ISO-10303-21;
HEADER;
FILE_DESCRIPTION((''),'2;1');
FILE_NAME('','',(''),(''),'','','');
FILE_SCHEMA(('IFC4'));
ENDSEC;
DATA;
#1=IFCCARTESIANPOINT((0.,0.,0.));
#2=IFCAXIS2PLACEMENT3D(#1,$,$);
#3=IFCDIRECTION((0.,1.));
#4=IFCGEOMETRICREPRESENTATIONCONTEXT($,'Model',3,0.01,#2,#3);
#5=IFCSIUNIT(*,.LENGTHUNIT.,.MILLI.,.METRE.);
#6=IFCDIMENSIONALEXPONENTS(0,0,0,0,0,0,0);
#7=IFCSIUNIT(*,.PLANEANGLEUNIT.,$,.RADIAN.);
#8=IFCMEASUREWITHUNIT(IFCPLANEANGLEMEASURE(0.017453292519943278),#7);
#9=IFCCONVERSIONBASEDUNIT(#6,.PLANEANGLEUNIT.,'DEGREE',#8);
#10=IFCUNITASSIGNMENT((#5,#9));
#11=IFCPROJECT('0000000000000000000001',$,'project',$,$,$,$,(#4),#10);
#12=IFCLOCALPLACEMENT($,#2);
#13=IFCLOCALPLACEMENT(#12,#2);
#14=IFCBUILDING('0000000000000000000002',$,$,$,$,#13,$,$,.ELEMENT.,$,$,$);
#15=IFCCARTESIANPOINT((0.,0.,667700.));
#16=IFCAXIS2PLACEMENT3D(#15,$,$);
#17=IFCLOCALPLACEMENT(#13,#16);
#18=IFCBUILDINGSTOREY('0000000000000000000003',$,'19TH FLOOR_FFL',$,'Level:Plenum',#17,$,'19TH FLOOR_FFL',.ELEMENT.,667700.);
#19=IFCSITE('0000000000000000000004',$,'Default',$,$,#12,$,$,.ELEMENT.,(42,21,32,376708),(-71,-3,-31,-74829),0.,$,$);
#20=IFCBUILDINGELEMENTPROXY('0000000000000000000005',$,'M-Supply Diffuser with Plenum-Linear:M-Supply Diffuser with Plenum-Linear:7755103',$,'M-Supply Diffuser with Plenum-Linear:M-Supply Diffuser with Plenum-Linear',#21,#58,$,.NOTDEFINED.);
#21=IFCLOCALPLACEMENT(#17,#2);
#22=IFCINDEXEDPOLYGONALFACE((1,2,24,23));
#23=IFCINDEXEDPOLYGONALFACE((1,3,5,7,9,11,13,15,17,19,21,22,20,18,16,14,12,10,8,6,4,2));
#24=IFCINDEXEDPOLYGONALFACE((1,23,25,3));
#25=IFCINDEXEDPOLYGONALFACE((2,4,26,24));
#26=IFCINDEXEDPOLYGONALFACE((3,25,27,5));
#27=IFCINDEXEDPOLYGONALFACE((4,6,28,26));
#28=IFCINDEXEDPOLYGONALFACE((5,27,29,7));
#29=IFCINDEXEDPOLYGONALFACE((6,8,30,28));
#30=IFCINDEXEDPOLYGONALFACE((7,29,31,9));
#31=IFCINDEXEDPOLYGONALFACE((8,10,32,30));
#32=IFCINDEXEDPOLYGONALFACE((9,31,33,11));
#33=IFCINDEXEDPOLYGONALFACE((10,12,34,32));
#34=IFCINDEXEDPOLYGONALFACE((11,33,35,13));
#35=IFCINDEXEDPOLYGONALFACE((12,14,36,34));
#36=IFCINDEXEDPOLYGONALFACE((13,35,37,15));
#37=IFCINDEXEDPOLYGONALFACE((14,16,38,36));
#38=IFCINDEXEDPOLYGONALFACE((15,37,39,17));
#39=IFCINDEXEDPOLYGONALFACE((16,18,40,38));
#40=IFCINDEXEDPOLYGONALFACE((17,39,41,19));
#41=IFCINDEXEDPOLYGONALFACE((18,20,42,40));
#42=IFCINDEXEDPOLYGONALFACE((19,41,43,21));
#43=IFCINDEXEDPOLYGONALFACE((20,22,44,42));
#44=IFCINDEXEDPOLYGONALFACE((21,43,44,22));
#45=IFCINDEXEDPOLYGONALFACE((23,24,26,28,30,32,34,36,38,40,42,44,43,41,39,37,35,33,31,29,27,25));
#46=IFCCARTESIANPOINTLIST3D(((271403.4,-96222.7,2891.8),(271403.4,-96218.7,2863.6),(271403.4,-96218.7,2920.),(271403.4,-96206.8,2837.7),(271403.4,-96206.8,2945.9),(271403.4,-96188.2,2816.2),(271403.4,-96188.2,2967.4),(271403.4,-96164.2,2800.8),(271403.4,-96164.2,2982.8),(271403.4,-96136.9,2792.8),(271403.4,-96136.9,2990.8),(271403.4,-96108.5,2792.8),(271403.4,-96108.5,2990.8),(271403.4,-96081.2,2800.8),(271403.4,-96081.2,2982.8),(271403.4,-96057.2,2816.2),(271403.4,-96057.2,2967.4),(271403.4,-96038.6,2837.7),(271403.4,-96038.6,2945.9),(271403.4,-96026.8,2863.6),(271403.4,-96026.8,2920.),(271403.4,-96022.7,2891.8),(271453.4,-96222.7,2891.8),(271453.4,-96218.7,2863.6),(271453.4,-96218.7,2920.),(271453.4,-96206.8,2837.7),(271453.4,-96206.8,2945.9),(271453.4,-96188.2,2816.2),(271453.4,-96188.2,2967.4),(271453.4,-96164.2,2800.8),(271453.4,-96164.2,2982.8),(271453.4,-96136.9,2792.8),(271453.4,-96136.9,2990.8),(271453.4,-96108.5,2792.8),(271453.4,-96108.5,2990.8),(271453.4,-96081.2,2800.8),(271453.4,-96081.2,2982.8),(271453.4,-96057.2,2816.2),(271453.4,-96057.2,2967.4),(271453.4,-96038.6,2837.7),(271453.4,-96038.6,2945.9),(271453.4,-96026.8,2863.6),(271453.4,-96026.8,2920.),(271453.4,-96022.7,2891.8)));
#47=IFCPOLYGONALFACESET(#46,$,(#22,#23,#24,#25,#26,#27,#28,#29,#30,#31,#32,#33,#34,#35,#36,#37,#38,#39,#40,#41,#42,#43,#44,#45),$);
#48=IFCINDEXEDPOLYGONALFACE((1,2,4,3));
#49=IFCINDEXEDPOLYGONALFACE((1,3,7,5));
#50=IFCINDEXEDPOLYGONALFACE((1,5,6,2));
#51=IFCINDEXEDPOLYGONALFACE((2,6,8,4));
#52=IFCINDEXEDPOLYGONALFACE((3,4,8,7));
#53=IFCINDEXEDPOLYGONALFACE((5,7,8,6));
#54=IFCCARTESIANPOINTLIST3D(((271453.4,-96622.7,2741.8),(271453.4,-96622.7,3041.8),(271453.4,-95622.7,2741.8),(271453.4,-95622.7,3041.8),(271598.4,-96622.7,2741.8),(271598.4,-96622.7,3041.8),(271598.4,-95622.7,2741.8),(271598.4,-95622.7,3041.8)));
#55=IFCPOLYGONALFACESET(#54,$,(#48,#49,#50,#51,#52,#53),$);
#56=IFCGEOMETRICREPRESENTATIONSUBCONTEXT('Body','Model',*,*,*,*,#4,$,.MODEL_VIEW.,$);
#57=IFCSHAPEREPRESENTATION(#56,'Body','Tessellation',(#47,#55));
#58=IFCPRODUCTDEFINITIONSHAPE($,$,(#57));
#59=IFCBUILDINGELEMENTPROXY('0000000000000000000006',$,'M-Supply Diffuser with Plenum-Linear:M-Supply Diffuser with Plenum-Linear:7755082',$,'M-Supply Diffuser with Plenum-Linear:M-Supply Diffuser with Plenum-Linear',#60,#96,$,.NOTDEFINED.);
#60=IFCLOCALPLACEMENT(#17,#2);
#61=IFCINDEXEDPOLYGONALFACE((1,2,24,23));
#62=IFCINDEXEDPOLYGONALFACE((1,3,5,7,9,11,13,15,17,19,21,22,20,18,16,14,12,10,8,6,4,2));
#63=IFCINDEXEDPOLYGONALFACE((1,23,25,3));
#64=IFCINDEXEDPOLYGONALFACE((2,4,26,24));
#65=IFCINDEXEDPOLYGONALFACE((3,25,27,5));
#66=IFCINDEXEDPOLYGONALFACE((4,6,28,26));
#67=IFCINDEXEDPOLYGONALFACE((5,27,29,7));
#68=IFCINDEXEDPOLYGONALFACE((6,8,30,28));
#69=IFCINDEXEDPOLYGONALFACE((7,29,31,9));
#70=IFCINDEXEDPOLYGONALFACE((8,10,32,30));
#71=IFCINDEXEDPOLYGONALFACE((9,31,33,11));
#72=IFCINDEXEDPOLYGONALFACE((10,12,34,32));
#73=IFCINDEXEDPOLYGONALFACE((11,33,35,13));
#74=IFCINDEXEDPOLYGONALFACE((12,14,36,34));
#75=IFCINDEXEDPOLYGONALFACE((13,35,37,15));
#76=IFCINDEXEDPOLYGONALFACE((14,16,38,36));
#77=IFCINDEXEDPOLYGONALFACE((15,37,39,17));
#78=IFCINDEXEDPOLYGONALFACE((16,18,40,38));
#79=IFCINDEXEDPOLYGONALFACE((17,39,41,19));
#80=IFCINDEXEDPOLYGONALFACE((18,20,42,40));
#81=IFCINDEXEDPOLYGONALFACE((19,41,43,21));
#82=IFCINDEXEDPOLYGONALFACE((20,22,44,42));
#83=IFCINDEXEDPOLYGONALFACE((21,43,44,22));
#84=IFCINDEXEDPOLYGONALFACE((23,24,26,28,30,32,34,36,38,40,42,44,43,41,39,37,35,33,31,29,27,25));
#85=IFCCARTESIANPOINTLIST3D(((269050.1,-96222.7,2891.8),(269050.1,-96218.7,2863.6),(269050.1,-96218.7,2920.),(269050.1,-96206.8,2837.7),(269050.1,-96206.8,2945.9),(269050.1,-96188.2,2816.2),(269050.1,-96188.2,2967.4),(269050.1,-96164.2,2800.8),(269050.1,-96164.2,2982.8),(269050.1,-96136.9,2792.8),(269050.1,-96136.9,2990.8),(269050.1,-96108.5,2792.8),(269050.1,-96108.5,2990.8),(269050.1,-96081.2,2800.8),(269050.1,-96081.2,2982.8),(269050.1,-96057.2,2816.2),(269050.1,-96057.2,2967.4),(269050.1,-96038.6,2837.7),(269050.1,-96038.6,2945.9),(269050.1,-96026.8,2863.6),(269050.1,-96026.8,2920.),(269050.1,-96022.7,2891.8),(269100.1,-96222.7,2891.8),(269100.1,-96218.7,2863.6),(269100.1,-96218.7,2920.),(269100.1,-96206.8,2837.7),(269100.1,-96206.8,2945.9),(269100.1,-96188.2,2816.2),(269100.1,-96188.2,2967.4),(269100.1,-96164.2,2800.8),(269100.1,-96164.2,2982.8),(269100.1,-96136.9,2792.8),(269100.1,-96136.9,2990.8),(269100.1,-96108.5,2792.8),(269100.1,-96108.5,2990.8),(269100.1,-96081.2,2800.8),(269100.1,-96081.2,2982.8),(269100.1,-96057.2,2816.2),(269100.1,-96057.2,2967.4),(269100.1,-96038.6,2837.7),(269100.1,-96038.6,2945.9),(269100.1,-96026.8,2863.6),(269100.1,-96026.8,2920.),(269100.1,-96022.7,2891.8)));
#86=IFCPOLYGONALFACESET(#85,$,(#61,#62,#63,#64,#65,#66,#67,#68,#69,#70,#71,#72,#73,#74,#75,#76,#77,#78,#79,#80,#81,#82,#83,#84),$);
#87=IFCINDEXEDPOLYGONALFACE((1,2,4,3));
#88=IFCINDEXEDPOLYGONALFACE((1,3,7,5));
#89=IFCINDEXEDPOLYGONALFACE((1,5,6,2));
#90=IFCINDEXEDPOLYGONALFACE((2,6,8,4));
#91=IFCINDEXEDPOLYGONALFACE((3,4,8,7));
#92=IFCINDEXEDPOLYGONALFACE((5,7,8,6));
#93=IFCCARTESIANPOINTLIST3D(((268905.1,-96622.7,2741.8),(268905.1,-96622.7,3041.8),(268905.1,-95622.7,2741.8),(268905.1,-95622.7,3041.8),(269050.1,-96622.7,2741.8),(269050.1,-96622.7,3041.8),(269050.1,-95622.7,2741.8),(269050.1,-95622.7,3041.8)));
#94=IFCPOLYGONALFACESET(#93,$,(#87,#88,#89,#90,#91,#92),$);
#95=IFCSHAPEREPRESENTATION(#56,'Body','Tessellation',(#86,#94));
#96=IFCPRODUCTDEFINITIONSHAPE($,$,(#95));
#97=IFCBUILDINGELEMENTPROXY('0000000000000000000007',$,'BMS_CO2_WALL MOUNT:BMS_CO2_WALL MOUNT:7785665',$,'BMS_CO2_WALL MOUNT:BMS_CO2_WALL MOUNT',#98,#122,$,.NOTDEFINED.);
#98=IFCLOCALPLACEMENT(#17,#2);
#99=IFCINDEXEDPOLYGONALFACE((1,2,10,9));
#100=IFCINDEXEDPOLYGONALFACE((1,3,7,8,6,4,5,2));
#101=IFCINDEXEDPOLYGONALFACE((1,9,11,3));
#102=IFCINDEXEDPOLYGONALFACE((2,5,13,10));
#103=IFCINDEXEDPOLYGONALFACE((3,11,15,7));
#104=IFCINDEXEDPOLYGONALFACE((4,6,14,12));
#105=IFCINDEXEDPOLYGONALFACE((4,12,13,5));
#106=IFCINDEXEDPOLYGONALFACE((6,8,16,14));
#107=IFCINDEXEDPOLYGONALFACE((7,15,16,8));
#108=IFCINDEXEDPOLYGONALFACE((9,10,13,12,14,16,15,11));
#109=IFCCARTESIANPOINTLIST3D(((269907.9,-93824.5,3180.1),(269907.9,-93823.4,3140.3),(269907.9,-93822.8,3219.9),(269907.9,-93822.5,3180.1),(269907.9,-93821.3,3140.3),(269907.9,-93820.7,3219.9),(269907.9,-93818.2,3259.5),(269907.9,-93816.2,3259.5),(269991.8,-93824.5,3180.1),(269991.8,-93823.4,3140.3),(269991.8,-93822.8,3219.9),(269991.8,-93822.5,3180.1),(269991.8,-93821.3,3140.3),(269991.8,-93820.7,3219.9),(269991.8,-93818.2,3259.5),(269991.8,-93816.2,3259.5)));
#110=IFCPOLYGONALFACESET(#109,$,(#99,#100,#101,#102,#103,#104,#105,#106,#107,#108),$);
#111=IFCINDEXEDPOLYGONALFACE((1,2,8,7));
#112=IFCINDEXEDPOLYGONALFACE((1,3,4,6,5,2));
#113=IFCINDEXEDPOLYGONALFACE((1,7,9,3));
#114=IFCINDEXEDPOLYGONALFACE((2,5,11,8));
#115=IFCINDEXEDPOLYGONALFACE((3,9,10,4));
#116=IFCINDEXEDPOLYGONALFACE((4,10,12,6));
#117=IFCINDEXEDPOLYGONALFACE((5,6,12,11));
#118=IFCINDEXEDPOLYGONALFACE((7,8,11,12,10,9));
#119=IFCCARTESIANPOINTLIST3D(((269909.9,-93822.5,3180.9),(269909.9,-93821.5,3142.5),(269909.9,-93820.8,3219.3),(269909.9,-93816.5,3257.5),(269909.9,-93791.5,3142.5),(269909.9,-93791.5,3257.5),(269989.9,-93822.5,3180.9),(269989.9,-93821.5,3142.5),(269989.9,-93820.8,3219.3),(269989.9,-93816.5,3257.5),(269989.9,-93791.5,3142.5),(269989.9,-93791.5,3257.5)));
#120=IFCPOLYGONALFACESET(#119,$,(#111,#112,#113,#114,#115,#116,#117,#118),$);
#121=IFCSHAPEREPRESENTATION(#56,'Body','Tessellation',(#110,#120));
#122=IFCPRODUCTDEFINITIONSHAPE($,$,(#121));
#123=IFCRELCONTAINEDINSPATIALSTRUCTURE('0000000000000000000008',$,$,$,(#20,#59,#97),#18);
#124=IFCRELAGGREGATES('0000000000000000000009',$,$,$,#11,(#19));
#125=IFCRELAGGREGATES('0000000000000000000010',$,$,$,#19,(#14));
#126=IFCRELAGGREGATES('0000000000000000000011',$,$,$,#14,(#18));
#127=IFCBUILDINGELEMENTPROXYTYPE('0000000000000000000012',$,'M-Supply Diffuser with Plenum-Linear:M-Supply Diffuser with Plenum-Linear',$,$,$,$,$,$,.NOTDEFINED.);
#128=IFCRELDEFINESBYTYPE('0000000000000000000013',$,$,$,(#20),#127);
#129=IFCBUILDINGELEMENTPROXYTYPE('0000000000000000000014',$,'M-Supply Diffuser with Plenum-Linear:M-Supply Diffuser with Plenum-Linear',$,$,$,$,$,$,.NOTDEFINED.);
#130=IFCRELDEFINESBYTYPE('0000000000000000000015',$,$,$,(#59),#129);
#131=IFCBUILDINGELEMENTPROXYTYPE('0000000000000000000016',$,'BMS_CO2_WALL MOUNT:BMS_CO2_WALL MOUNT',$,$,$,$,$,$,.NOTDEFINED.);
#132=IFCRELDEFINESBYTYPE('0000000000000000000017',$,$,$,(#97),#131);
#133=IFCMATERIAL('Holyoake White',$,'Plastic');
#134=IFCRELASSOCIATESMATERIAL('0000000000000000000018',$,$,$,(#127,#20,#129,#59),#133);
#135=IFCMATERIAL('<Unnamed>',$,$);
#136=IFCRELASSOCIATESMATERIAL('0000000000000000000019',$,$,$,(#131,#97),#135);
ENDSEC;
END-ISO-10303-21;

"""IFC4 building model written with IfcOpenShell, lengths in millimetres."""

from ifc_helpers import new_model, entity, si_unit, converted_unit, direction, frame, origin, place, context, subcontext, project, spatial, line, arc, indexed_curve, outline, extrude, source, transform, mapped, material, type_object, type_shapes, element, save


model = new_model("IFC4")

# Units and contexts
model_context = context("Model", 3, precision=0.01, world=origin(), true_north=direction((0.0, 1.0)))
body_context = subcontext(model_context, "Body", "Model", "MODEL_VIEW")
ifc_project = project(units=[si_unit("LENGTHUNIT", "METRE", prefix="MILLI"), converted_unit("PLANEANGLEUNIT", "DEGREE", entity("IfcPlaneAngleMeasure", 0.017453292519943278), si_unit("PLANEANGLEUNIT", "RADIAN"), dimensions=[0, 0, 0, 0, 0, 0, 0])], contexts=[model_context])

# Site, building, storey
site_placement = place(None, origin())
site = spatial("IfcSite", under=ifc_project, at=site_placement, Name="Default", CompositionType="ELEMENT", RefLatitude=(42, 21, 32, 376708), RefLongitude=(-71, -3, -31, -74829), RefElevation=0.0)
building_placement = place(site_placement, origin())
building = spatial("IfcBuilding", under=site, at=building_placement, CompositionType="ELEMENT")
storey_placement = place(building_placement, frame((0.0, 0.0, 667700.0)))
storey = spatial("IfcBuildingStorey", under=building, at=storey_placement, Name="19TH FLOOR_FFL", ObjectType="Level:Plenum", LongName="19TH FLOOR_FFL", CompositionType="ELEMENT", Elevation=667700.0)

# Shared definitions
ifc_material_1 = material(Name="<Unnamed>")

# Building element proxies
ifc_material_2 = material(Name="Holyoake White", Category="Plastic")
building_element_proxy_type_1 = type_object("IfcBuildingElementProxyType", Name="M-Supply Diffuser with Plenum-Linear:M-Supply Diffuser with Plenum-Linear", PredefinedType="NOTDEFINED", material=ifc_material_2)
shared_shape_1 = source(origin(), body_context, "Body", "SweptSolid", [
    extrude(outline(indexed_curve([(-100.0, 0.0), (0.0, -100.0), (100.0, 0.0), (0.0, 100.0)], segments=[arc(1, 2, 3), arc(3, 4, 1)], self_intersect=False)), frame((0.0, 72.5, 195.0), z_axis=(0.0, 1.0, 0.0), x_axis=(1.0, 0.0, 0.0)), (0.0, 0.0, 1.0), 50.0),
    extrude(outline(indexed_curve([(-72.5, -500.0), (72.5, -500.0), (72.5, 500.0), (-72.5, 500.0), (-72.5, -500.0)], self_intersect=False)), frame((0.0, 0.0, 45.0), z_axis=(0.0, 0.0, 1.0), x_axis=(0.0, 1.0, 0.0)), (0.0, 0.0, 1.0), 300.0),
])
type_shapes(building_element_proxy_type_1, [shared_shape_1])
proxy_1_placement = place(storey_placement, frame((271525.9, -96122.7, 2696.8), z_axis=(0.0, 0.0, 1.0), x_axis=(0.0, 1.0, 0.0)))
element("IfcBuildingElementProxy", 1, at=proxy_1_placement, inside=storey, type_object=building_element_proxy_type_1, material=ifc_material_2, Name="M-Supply Diffuser with Plenum-Linear:M-Supply Diffuser with Plenum-Linear:7755103", ObjectType="M-Supply Diffuser with Plenum-Linear:M-Supply Diffuser with Plenum-Linear", PredefinedType="NOTDEFINED", context=body_context, shape_type="MappedRepresentation", body=[
    mapped(shared_shape_1, transform((0.0, 0.0, 0.0), scale=1.0)),
])
building_element_proxy_type_2 = type_object("IfcBuildingElementProxyType", Name="M-Supply Diffuser with Plenum-Linear:M-Supply Diffuser with Plenum-Linear", PredefinedType="NOTDEFINED", material=ifc_material_2)
shared_shape_2 = source(origin(), body_context, "Body", "SweptSolid", [
    extrude(outline(indexed_curve([(-100.0, 0.0), (0.0, -100.0), (100.0, 0.0), (0.0, 100.0)], segments=[arc(1, 2, 3), arc(3, 4, 1)], self_intersect=False)), frame((0.0, -122.5, 195.0), z_axis=(0.0, 1.0, 0.0), x_axis=(1.0, 0.0, 0.0)), (0.0, 0.0, 1.0), 50.0),
    extrude(outline(indexed_curve([(-500.0, -72.5), (500.0, -72.5), (500.0, 72.5), (-500.0, 72.5), (-500.0, -72.5)], self_intersect=False)), frame((0.0, 0.0, 45.0), z_axis=(0.0, 0.0, 1.0), x_axis=(-1.0, 0.0, 0.0)), (0.0, 0.0, 1.0), 300.0),
])
type_shapes(building_element_proxy_type_2, [shared_shape_2])
proxy_2_placement = place(storey_placement, frame((268977.6, -96122.7, 2696.8), z_axis=(0.0, 0.0, 1.0), x_axis=(0.0, 1.0, 0.0)))
element("IfcBuildingElementProxy", 2, at=proxy_2_placement, inside=storey, type_object=building_element_proxy_type_2, material=ifc_material_2, Name="M-Supply Diffuser with Plenum-Linear:M-Supply Diffuser with Plenum-Linear:7755082", ObjectType="M-Supply Diffuser with Plenum-Linear:M-Supply Diffuser with Plenum-Linear", PredefinedType="NOTDEFINED", context=body_context, shape_type="MappedRepresentation", body=[
    mapped(shared_shape_2, transform((0.0, 0.0, 0.0), scale=1.0)),
])
building_element_proxy_type_3 = type_object("IfcBuildingElementProxyType", Name="BMS_CO2_WALL MOUNT:BMS_CO2_WALL MOUNT", PredefinedType="NOTDEFINED", material=ifc_material_1)
shared_shape_3 = source(origin(), body_context, "Body", "SweptSolid", [
    extrude(outline(indexed_curve([(-59.6, -1.6), (-59.6, -3.6), (0.1, -4.2), (59.6, 1.6), (59.6, 3.6), (0.1, -2.2)], segments=[line(1, 2), arc(2, 3, 4), line(4, 5), arc(5, 6, 1)], self_intersect=False)), frame((-42.0, -0.1, 28.3), z_axis=(-1.0, 0.0, 0.0), x_axis=(0.0, 1.0, 0.0)), (0.0, 0.0, -1.0), 84.0),
    extrude(outline(indexed_curve([(-13.7, -57.5), (11.3, -57.5), (16.7, -0.1), (16.2, 57.5), (-13.7, 57.5)], segments=[line(1, 2), arc(2, 3, 4), line(4, 5, 1)], self_intersect=False)), frame((-40.0, 0.0, 13.7), z_axis=(1.0, 0.0, 0.0), x_axis=(0.0, 0.0, 1.0)), (0.0, 0.0, 1.0), 80.0),
])
type_shapes(building_element_proxy_type_3, [shared_shape_3])
proxy_3_placement = place(storey_placement, frame((269949.9, -93791.5, 3200.0), z_axis=(0.0, -1.0, 0.0), x_axis=(1.0, 0.0, 0.0)))
element("IfcBuildingElementProxy", 3, at=proxy_3_placement, inside=storey, type_object=building_element_proxy_type_3, material=ifc_material_1, Name="BMS_CO2_WALL MOUNT:BMS_CO2_WALL MOUNT:7785665", ObjectType="BMS_CO2_WALL MOUNT:BMS_CO2_WALL MOUNT", PredefinedType="NOTDEFINED", context=body_context, shape_type="MappedRepresentation", body=[
    mapped(shared_shape_3, transform((0.0, 0.0, 0.0), scale=1.0)),
])

save(model, "model.ifc")
